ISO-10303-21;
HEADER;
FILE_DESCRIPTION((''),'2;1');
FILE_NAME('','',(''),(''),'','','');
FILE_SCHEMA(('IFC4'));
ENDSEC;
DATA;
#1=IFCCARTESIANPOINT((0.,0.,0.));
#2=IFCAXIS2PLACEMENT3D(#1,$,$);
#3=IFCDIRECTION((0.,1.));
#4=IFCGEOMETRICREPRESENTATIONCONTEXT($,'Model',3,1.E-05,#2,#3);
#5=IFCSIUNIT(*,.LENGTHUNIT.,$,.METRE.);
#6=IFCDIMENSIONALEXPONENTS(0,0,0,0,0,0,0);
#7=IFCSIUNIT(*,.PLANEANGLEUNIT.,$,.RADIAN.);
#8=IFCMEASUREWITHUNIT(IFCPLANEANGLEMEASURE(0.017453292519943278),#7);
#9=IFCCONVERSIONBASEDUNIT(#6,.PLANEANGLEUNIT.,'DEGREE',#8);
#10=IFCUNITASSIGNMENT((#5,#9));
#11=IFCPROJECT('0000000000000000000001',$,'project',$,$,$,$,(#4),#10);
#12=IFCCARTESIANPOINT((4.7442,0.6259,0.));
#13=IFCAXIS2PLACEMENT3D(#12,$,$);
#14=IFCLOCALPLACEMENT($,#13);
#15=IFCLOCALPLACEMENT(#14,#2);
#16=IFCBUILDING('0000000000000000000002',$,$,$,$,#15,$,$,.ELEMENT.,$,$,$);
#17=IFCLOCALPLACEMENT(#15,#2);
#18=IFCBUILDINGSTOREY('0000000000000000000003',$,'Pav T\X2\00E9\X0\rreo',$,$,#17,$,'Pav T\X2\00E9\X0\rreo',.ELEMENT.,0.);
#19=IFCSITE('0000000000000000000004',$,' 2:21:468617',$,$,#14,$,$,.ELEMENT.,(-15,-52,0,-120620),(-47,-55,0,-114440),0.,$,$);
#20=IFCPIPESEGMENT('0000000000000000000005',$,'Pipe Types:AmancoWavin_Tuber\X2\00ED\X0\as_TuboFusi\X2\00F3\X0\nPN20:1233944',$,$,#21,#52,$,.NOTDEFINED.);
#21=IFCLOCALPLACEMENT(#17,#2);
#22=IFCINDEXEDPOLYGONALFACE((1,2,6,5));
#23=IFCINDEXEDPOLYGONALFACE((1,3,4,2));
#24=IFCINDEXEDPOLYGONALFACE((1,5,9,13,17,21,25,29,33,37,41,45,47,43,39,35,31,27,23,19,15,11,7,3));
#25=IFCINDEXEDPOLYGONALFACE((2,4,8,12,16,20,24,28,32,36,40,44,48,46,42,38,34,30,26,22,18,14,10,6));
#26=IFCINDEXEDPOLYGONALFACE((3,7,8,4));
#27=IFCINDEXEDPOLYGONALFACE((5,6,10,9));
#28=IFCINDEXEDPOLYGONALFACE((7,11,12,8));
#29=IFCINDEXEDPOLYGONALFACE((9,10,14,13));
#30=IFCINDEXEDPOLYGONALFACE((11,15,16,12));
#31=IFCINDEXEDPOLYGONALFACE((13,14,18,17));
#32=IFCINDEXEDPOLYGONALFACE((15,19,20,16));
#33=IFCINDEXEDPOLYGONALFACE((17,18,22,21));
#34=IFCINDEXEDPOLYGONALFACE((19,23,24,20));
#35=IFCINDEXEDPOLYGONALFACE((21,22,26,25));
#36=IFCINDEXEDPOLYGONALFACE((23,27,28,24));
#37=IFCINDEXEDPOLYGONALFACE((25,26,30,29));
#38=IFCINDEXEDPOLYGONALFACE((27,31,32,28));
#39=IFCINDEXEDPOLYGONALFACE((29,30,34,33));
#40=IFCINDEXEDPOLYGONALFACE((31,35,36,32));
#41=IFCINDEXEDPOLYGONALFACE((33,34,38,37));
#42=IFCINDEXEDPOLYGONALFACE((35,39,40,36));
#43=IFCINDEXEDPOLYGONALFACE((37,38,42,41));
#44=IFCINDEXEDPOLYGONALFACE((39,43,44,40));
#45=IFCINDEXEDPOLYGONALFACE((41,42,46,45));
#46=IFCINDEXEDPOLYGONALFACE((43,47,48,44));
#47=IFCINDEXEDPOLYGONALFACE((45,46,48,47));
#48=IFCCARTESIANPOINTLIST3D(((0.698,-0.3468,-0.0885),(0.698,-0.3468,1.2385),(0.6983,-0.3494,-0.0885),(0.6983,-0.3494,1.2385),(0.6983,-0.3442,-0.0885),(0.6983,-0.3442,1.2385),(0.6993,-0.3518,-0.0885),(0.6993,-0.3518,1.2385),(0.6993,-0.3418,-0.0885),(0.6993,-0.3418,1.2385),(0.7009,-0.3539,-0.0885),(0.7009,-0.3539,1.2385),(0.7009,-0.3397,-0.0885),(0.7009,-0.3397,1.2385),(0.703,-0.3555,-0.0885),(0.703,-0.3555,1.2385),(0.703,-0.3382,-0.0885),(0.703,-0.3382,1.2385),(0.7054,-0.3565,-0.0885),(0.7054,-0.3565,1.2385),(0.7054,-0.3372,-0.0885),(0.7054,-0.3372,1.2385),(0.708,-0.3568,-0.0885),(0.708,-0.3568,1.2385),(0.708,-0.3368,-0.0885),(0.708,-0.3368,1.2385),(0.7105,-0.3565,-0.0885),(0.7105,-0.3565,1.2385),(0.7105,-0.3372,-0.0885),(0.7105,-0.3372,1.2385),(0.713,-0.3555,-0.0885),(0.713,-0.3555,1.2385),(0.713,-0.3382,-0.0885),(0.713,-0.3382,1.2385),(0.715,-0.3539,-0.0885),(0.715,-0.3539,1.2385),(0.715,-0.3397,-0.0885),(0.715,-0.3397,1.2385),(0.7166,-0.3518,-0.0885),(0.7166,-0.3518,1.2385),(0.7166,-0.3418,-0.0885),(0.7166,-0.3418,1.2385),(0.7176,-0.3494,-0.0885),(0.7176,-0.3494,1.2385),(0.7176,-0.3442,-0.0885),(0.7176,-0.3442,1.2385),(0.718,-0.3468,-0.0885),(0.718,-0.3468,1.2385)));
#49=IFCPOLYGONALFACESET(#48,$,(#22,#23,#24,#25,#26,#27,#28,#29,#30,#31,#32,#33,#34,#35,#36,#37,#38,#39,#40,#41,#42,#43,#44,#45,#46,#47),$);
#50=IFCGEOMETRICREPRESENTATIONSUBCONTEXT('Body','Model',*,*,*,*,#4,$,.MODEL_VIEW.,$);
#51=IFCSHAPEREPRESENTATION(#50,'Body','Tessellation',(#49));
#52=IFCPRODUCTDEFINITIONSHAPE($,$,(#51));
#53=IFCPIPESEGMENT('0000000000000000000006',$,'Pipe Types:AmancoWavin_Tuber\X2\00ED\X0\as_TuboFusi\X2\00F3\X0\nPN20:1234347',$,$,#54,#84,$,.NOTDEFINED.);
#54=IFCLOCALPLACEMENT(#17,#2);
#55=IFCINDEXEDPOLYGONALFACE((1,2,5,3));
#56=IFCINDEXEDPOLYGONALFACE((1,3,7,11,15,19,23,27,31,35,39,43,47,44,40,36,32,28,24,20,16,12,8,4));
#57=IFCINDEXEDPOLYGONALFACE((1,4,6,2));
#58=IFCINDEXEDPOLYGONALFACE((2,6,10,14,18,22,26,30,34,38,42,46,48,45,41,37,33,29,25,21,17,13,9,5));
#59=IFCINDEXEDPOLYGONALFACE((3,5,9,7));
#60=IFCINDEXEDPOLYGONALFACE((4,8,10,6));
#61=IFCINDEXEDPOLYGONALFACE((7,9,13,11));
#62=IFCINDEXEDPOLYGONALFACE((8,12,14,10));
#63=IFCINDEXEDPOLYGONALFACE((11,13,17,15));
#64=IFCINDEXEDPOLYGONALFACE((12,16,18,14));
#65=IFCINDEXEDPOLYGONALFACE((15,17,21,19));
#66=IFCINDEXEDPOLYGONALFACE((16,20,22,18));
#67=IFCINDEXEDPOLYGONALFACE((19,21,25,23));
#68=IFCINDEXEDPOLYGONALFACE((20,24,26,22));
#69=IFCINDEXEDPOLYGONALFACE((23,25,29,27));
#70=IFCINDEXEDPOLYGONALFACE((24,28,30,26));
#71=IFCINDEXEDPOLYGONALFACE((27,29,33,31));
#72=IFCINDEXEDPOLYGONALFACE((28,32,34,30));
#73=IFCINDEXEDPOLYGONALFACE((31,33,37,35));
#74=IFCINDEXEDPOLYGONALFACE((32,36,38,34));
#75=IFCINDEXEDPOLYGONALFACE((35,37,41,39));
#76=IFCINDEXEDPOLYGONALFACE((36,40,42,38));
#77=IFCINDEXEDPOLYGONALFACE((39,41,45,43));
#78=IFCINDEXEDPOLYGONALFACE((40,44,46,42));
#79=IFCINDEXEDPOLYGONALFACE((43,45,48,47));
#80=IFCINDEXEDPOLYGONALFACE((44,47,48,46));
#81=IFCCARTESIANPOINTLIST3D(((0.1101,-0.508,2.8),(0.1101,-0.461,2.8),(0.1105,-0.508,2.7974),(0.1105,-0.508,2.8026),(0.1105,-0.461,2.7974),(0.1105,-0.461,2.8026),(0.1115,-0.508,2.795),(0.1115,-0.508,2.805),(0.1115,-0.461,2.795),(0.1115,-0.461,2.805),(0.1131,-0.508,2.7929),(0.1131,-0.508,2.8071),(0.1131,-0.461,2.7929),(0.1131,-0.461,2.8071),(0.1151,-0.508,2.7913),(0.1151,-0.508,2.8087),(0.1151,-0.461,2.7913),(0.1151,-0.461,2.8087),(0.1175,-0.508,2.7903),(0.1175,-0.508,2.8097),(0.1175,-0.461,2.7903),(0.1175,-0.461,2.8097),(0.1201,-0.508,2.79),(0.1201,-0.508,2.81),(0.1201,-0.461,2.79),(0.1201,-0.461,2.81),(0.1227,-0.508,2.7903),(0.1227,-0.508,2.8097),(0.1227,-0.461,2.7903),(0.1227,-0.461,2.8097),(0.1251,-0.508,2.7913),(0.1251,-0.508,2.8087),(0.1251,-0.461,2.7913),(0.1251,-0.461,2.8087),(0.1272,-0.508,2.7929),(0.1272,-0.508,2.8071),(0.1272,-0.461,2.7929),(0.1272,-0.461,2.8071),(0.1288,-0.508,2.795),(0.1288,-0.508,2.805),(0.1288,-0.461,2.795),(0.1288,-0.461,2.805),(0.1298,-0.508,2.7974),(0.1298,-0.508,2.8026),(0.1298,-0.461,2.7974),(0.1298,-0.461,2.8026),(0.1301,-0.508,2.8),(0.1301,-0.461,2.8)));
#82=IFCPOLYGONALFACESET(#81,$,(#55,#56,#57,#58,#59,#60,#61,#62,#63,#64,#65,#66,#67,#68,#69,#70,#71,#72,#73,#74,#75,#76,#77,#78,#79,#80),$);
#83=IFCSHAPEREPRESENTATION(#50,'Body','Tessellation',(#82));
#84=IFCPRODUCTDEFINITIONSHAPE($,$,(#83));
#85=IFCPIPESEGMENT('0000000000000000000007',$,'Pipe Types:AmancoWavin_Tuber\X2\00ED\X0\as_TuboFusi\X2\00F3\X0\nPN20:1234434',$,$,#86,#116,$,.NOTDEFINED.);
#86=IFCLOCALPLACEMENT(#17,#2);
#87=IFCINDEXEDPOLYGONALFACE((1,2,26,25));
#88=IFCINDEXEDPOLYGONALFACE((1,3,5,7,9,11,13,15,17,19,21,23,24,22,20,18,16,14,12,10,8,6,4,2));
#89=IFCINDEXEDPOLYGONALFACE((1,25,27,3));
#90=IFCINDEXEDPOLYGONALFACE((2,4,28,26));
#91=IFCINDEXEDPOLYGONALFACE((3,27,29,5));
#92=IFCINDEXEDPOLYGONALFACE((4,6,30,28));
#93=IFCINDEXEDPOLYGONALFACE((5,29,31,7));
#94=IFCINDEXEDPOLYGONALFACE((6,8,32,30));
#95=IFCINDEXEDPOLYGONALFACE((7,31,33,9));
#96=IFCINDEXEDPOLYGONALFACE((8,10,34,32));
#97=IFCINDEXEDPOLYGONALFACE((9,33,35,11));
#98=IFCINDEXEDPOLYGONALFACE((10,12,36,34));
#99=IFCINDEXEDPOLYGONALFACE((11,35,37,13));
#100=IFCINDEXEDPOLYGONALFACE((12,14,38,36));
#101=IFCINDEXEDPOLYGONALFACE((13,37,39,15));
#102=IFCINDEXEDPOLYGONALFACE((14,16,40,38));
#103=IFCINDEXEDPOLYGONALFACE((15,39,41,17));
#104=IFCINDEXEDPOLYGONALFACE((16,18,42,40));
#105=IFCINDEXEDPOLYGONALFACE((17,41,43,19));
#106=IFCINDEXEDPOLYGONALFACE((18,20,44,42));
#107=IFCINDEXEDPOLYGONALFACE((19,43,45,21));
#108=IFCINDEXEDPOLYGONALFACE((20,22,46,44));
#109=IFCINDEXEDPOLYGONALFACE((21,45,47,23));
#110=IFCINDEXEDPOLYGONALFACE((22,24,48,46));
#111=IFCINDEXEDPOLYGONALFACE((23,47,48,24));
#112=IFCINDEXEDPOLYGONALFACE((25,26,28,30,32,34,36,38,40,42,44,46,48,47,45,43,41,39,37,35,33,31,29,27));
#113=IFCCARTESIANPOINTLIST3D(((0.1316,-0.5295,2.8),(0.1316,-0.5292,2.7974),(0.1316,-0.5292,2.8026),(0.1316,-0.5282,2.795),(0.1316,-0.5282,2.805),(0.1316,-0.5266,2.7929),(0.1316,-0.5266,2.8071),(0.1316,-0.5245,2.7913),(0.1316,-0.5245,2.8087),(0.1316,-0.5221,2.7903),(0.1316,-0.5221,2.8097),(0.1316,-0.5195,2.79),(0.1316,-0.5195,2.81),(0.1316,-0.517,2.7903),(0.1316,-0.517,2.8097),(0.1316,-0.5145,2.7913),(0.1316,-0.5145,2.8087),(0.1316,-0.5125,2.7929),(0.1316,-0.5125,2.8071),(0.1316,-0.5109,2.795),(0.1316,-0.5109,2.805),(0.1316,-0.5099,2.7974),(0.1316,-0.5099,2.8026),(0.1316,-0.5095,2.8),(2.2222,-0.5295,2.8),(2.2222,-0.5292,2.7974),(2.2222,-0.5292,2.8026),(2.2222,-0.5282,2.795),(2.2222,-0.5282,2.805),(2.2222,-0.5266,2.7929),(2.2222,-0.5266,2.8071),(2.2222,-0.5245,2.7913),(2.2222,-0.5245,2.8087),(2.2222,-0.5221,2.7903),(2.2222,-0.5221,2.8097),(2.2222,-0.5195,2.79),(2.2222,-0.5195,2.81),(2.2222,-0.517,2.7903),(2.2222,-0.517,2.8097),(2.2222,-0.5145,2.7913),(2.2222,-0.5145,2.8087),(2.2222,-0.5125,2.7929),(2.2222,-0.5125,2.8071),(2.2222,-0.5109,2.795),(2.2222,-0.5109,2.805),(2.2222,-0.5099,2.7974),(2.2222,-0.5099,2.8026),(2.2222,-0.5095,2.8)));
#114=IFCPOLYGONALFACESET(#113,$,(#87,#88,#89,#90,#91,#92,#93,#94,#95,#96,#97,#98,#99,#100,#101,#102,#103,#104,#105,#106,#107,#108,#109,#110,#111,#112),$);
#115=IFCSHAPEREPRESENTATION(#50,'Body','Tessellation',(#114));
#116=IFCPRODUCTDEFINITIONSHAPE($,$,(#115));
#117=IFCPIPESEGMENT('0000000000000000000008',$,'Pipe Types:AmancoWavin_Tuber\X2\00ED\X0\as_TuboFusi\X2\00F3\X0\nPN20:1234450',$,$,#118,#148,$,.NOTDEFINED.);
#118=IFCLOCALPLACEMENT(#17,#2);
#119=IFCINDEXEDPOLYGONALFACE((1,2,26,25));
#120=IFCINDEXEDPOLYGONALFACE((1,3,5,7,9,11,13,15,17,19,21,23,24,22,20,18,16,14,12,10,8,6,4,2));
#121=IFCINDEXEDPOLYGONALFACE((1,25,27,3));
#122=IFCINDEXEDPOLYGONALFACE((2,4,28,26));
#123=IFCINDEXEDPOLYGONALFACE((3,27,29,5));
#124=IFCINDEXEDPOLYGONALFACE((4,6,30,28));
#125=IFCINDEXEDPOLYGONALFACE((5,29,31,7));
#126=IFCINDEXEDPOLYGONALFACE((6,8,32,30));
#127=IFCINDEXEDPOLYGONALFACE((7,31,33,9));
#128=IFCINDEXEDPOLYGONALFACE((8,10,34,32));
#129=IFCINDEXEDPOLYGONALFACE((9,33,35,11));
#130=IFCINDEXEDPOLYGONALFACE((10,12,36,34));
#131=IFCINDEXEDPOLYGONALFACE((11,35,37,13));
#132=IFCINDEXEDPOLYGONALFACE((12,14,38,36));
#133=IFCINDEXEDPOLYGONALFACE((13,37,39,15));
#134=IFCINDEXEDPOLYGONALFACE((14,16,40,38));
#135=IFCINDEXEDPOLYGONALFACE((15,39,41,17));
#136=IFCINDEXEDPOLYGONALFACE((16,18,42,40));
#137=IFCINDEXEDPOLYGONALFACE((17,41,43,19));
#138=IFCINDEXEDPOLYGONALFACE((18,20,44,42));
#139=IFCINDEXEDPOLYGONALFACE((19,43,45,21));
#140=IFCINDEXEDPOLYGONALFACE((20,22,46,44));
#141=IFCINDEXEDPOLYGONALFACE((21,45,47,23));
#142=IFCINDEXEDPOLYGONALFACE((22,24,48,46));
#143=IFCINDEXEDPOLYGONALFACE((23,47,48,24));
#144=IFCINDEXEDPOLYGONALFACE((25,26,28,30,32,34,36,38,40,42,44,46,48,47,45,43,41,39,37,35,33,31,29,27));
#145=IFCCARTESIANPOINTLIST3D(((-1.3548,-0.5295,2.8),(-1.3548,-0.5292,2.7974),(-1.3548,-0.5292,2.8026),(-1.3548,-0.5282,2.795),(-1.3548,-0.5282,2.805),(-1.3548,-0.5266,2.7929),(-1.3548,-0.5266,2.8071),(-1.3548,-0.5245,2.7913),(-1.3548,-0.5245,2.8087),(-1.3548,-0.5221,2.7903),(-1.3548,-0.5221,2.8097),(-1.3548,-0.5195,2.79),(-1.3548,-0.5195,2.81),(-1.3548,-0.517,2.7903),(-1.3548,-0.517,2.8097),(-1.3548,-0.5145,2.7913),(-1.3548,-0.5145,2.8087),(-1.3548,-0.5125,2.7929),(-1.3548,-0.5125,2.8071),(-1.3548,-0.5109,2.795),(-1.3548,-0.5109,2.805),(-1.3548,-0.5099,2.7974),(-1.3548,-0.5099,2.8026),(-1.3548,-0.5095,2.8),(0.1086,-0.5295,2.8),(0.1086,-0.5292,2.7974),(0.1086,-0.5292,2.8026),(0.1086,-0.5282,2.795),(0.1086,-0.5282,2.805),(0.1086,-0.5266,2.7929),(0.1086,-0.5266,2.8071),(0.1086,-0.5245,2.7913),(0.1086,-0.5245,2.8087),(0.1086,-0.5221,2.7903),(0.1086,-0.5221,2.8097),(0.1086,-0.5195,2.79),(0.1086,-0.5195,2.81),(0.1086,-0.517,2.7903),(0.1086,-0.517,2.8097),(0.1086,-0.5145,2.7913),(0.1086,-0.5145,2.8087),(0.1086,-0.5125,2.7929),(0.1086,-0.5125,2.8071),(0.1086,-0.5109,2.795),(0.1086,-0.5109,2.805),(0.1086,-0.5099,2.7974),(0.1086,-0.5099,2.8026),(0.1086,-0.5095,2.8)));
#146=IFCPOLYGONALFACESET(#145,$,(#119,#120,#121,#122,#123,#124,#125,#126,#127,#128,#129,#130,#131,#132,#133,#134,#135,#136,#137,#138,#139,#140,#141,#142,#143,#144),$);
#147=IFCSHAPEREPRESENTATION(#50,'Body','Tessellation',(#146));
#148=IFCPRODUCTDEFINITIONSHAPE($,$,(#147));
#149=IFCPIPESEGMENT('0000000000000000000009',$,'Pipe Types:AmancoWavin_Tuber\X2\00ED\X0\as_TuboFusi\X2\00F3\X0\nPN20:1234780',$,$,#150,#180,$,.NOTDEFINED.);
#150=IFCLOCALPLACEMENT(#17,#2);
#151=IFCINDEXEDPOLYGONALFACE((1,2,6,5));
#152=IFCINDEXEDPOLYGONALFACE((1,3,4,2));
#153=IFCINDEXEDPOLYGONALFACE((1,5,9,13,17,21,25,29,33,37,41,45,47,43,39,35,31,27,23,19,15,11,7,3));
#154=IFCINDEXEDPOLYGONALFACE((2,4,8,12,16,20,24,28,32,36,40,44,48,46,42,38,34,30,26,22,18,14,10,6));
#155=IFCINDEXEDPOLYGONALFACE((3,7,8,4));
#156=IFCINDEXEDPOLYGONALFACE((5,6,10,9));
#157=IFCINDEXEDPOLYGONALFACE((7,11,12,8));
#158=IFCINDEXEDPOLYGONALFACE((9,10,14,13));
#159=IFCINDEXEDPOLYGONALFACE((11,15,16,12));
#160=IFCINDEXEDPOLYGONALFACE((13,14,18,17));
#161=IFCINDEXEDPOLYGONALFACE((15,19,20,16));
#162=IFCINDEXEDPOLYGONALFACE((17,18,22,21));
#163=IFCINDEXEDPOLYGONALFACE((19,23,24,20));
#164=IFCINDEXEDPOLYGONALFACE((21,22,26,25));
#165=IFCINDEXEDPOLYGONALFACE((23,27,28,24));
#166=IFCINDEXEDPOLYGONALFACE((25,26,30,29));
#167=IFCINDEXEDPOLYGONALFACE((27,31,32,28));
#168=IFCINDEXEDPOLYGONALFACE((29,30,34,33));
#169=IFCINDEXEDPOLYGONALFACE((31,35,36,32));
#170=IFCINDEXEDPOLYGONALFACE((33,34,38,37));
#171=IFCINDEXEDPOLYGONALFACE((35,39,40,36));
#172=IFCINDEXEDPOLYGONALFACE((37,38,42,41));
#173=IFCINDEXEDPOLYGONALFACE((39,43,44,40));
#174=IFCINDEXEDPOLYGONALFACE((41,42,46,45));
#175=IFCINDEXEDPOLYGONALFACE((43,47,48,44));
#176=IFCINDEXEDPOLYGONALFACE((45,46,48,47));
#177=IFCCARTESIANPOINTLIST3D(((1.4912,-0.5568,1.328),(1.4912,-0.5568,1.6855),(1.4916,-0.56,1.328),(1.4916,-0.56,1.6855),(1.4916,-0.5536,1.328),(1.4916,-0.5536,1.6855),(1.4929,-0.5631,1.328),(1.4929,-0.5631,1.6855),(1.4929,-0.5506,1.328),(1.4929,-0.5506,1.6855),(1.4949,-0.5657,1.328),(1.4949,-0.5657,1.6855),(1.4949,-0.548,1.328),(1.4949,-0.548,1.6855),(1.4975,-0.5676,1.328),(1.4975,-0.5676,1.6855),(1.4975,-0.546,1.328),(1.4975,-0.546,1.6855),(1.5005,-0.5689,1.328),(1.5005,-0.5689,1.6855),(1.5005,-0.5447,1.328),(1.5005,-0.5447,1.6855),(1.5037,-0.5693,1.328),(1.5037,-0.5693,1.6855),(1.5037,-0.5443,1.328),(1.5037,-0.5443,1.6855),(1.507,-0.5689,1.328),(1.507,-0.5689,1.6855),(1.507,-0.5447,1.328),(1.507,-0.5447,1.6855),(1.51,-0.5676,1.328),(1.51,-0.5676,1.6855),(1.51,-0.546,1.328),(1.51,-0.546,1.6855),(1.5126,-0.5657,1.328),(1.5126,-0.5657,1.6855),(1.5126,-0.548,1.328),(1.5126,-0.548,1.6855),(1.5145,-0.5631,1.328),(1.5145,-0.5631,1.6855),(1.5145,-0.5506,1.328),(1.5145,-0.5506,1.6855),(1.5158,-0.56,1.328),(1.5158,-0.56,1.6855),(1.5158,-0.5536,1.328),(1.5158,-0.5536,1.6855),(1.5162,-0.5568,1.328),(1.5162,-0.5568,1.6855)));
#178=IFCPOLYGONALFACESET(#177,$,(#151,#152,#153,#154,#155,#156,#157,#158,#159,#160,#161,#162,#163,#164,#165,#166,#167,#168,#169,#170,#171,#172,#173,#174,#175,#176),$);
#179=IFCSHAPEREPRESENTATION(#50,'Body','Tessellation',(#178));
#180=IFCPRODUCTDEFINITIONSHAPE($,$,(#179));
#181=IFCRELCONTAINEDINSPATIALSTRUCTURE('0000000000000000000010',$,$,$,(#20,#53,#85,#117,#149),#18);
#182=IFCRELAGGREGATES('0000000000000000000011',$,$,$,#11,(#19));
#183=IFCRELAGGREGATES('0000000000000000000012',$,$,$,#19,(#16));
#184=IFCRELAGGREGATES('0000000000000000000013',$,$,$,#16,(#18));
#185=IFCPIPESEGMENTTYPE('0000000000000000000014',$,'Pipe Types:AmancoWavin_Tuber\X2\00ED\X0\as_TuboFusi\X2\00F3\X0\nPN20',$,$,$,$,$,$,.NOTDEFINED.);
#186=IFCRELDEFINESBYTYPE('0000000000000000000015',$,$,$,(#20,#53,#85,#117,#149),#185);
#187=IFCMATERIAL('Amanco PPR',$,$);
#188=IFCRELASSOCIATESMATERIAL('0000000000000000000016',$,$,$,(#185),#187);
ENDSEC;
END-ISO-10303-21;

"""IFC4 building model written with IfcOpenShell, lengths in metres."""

from ifc_helpers import new_model, entity, si_unit, converted_unit, direction, frame, origin, place, context, subcontext, project, spatial, arc, indexed_curve, outline, extrude, material, type_object, element, save


model = new_model("IFC4")

# Units and contexts
model_context = context("Model", 3, precision=1e-05, world=origin(), true_north=direction((0.0, 1.0)))
body_context = subcontext(model_context, "Body", "Model", "MODEL_VIEW")
ifc_project = project(units=[si_unit("LENGTHUNIT", "METRE"), converted_unit("PLANEANGLEUNIT", "DEGREE", entity("IfcPlaneAngleMeasure", 0.017453292519943278), si_unit("PLANEANGLEUNIT", "RADIAN"), dimensions=[0, 0, 0, 0, 0, 0, 0])], contexts=[model_context])

# Site, building, storey
site_placement = place(None, frame((4.7442, 0.6259, 0.0)))
site = spatial("IfcSite", under=ifc_project, at=site_placement, Name=" 2:21:468617", CompositionType="ELEMENT", RefLatitude=(-15, -52, 0, -120620), RefLongitude=(-47, -55, 0, -114440), RefElevation=0.0)
building_placement = place(site_placement, origin())
building = spatial("IfcBuilding", under=site, at=building_placement, CompositionType="ELEMENT")
storey_placement = place(building_placement, origin())
storey = spatial("IfcBuildingStorey", under=building, at=storey_placement, Name="Pav Térreo", LongName="Pav Térreo", CompositionType="ELEMENT", Elevation=0.0)

# Pipe segments
ifc_material_1 = material(Name="Amanco PPR")
pipe_segment_type_1 = type_object("IfcPipeSegmentType", Name="Pipe Types:AmancoWavin_Tuberías_TuboFusiónPN20", PredefinedType="NOTDEFINED", material=ifc_material_1)
pipe_segment_1_placement = place(storey_placement, origin())
element("IfcPipeSegment", 1, at=pipe_segment_1_placement, inside=storey, type_object=pipe_segment_type_1, Name="Pipe Types:AmancoWavin_Tuberías_TuboFusiónPN20:1233944", PredefinedType="NOTDEFINED", context=body_context, shape_type="SweptSolid", body=[
    extrude(outline(indexed_curve([(0.01, 0.0), (0.0071, 0.0071), (0.0, 0.01), (-0.0071, 0.0071), (-0.01, 0.0), (-0.0071, -0.0071), (0.0, -0.01), (0.0071, -0.0071)], segments=[arc(1, 2, 3), arc(3, 4, 5), arc(5, 6, 7), arc(7, 8, 1)], self_intersect=False)), frame((0.708, -0.3468, -0.0885), z_axis=(0.0, 0.0, 1.0), x_axis=(-1.0, 0.0, 0.0)), (0.0, 0.0, 1.0), 1.327),
])
pipe_segment_2_placement = place(storey_placement, origin())
element("IfcPipeSegment", 2, at=pipe_segment_2_placement, inside=storey, type_object=pipe_segment_type_1, Name="Pipe Types:AmancoWavin_Tuberías_TuboFusiónPN20:1234347", PredefinedType="NOTDEFINED", context=body_context, shape_type="SweptSolid", body=[
    extrude(outline(indexed_curve([(0.01, 0.0), (0.0071, 0.0071), (0.0, 0.01), (-0.0071, 0.0071), (-0.01, 0.0), (-0.0071, -0.0071), (0.0, -0.01), (0.0071, -0.0071)], segments=[arc(1, 2, 3), arc(3, 4, 5), arc(5, 6, 7), arc(7, 8, 1)], self_intersect=False)), frame((0.1201, -0.508, 2.8), z_axis=(0.0, 1.0, 0.0), x_axis=(-1.0, 0.0, 0.0)), (0.0, 0.0, 1.0), 0.047),
])
pipe_segment_3_placement = place(storey_placement, origin())
element("IfcPipeSegment", 3, at=pipe_segment_3_placement, inside=storey, type_object=pipe_segment_type_1, Name="Pipe Types:AmancoWavin_Tuberías_TuboFusiónPN20:1234434", PredefinedType="NOTDEFINED", context=body_context, shape_type="SweptSolid", body=[
    extrude(outline(indexed_curve([(0.01, 0.0), (0.0071, 0.0071), (0.0, 0.01), (-0.0071, 0.0071), (-0.01, 0.0), (-0.0071, -0.0071), (0.0, -0.01), (0.0071, -0.0071)], segments=[arc(1, 2, 3), arc(3, 4, 5), arc(5, 6, 7), arc(7, 8, 1)], self_intersect=False)), frame((0.1316, -0.5195, 2.8), z_axis=(1.0, 0.0, 0.0), x_axis=(0.0, -1.0, 0.0)), (0.0, 0.0, 1.0), 2.0906),
])
pipe_segment_4_placement = place(storey_placement, origin())
element("IfcPipeSegment", 4, at=pipe_segment_4_placement, inside=storey, type_object=pipe_segment_type_1, Name="Pipe Types:AmancoWavin_Tuberías_TuboFusiónPN20:1234450", PredefinedType="NOTDEFINED", context=body_context, shape_type="SweptSolid", body=[
    extrude(outline(indexed_curve([(0.01, 0.0), (0.0071, 0.0071), (0.0, 0.01), (-0.0071, 0.0071), (-0.01, 0.0), (-0.0071, -0.0071), (0.0, -0.01), (0.0071, -0.0071)], segments=[arc(1, 2, 3), arc(3, 4, 5), arc(5, 6, 7), arc(7, 8, 1)], self_intersect=False)), frame((-1.3548, -0.5195, 2.8), z_axis=(1.0, 0.0, 0.0), x_axis=(0.0, -1.0, 0.0)), (0.0, 0.0, 1.0), 1.4634),
])
pipe_segment_5_placement = place(storey_placement, origin())
element("IfcPipeSegment", 5, at=pipe_segment_5_placement, inside=storey, type_object=pipe_segment_type_1, Name="Pipe Types:AmancoWavin_Tuberías_TuboFusiónPN20:1234780", PredefinedType="NOTDEFINED", context=body_context, shape_type="SweptSolid", body=[
    extrude(outline(indexed_curve([(0.0125, 0.0), (0.0088, 0.0088), (0.0, 0.0125), (-0.0088, 0.0088), (-0.0125, 0.0), (-0.0088, -0.0088), (0.0, -0.0125), (0.0088, -0.0088)], segments=[arc(1, 2, 3), arc(3, 4, 5), arc(5, 6, 7), arc(7, 8, 1)], self_intersect=False)), frame((1.5037, -0.5568, 1.328)), (0.0, 0.0, 1.0), 0.3575),
])

save(model, "model.ifc")
